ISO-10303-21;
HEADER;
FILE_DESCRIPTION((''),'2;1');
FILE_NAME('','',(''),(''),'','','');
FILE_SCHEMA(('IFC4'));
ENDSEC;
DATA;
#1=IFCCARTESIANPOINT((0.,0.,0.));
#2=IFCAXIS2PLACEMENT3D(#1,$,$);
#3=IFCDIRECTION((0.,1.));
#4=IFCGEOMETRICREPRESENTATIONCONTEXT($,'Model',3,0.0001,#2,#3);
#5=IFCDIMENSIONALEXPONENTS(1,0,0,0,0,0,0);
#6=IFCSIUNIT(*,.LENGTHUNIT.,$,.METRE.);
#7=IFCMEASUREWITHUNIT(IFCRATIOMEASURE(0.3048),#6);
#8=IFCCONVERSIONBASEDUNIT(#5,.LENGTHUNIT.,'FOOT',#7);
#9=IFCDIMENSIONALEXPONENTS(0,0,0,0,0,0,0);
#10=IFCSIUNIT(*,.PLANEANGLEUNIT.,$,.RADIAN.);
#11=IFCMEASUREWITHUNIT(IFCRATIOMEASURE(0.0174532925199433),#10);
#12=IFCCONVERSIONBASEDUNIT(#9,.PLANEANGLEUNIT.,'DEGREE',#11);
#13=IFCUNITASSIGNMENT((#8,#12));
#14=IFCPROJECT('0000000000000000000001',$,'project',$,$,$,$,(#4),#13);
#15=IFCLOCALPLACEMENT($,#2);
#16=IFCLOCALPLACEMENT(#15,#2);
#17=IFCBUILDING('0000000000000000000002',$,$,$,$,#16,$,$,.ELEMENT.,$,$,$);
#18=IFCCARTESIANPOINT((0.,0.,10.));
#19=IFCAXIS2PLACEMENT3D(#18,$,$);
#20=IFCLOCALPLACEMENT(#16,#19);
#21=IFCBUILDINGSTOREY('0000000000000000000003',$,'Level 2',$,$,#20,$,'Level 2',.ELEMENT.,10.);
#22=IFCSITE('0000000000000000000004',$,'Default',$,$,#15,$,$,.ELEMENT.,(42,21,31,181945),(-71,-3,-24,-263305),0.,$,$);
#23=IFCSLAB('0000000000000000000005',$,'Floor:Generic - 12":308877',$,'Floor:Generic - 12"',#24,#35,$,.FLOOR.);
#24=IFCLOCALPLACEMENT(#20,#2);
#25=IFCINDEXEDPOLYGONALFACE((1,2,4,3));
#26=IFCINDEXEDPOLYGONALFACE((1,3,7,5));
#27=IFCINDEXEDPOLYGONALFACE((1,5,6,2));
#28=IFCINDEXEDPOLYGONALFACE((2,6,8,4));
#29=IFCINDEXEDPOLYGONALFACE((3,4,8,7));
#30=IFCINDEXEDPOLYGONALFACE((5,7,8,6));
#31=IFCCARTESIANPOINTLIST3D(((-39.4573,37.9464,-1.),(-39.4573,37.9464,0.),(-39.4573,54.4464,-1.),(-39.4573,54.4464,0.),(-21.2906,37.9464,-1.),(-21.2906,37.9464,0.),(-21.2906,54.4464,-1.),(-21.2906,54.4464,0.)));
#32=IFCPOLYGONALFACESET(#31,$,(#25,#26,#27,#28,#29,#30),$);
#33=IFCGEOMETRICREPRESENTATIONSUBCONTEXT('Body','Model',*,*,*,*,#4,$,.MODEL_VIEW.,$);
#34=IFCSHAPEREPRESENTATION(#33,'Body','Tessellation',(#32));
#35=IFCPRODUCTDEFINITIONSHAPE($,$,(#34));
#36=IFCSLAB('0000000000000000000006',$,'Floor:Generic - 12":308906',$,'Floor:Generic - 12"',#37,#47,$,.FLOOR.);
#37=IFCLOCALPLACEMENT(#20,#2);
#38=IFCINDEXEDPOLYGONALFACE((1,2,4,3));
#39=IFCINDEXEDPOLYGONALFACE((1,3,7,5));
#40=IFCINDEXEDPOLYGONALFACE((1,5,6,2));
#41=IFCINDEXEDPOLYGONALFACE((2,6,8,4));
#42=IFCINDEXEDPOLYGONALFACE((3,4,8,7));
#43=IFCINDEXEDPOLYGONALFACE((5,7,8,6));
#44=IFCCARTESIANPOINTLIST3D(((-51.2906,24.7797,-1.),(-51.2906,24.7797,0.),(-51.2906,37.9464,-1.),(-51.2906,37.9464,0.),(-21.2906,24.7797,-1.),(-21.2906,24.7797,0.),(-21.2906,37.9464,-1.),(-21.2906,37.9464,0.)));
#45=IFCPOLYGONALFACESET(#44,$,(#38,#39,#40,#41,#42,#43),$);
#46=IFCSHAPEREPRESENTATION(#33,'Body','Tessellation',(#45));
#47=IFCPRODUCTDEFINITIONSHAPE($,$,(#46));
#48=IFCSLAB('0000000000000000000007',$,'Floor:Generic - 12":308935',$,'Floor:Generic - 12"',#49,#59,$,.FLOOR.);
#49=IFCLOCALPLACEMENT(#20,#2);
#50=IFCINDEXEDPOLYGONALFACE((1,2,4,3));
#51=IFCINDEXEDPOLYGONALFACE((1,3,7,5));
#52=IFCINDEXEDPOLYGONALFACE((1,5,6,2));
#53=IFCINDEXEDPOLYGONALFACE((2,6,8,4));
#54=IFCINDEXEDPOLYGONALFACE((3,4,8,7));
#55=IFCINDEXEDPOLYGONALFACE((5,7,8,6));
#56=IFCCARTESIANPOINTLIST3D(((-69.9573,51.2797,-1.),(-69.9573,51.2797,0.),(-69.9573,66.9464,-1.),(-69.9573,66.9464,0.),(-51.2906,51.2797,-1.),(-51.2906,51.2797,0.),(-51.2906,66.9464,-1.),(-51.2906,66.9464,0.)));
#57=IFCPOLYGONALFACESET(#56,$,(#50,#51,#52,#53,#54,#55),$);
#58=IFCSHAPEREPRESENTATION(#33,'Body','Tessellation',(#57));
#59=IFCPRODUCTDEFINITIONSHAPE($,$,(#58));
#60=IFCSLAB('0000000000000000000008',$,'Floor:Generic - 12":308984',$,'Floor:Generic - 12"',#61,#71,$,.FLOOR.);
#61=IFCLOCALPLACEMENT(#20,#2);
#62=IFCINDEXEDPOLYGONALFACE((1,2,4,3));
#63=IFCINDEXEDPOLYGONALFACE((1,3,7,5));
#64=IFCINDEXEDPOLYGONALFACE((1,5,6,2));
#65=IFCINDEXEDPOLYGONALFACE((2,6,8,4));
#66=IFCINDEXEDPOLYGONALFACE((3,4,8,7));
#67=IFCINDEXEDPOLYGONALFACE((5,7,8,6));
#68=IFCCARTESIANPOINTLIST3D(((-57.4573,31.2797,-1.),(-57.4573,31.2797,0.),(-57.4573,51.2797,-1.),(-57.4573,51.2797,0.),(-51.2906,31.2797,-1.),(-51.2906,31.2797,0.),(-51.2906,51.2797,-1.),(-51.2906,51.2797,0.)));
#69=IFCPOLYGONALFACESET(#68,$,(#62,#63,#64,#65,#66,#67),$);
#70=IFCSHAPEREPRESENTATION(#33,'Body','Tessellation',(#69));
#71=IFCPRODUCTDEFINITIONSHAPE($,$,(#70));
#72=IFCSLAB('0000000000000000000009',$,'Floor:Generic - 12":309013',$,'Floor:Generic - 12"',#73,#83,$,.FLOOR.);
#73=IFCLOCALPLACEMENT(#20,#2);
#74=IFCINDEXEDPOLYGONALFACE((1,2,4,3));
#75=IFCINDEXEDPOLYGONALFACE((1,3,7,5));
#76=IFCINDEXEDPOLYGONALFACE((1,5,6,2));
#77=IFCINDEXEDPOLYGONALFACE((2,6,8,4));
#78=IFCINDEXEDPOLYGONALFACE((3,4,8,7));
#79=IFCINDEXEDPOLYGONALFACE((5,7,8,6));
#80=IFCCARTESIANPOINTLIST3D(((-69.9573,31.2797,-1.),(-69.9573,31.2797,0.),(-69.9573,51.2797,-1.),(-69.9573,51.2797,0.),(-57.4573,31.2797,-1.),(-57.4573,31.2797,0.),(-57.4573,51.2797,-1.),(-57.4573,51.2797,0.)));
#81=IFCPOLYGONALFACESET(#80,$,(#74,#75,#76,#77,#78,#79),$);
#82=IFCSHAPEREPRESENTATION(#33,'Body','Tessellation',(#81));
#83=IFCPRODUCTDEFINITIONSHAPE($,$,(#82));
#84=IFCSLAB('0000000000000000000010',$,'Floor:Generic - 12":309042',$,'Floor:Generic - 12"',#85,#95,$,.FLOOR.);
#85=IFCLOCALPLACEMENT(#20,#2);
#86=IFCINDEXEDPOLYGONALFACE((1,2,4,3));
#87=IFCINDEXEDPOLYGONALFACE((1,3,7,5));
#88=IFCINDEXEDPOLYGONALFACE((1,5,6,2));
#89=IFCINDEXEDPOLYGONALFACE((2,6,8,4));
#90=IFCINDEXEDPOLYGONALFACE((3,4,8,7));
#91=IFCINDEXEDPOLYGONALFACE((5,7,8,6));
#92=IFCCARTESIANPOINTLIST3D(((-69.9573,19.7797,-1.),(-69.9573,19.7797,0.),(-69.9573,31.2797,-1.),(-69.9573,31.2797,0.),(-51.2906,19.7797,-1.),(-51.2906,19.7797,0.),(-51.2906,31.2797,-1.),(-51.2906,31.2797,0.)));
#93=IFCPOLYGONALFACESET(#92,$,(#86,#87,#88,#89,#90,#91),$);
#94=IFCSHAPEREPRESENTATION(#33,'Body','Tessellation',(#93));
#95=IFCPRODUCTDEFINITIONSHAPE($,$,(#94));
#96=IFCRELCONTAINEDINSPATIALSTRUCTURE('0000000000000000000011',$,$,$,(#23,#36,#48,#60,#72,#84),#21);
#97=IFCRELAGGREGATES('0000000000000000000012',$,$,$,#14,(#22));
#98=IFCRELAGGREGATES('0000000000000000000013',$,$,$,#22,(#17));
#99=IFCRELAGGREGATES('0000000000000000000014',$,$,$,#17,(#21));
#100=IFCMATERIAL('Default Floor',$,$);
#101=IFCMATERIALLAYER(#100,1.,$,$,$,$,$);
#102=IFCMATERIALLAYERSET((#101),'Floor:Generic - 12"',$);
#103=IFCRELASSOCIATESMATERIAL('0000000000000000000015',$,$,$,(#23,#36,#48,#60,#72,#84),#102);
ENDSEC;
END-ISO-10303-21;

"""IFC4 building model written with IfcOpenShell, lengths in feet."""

from ifc_helpers import new_model, entity, si_unit, converted_unit, direction, frame, frame_2d, origin, place, context, subcontext, project, spatial, rectangle, extrude, material, layer, layer_set, layer_usage, element, save


model = new_model("IFC4")

# Units and contexts
model_context = context("Model", 3, precision=0.0001, world=origin(), true_north=direction((0.0, 1.0)))
body_context = subcontext(model_context, "Body", "Model", "MODEL_VIEW")
ifc_project = project(units=[converted_unit("LENGTHUNIT", "FOOT", entity("IfcRatioMeasure", 0.3048), si_unit("LENGTHUNIT", "METRE"), dimensions=[1, 0, 0, 0, 0, 0, 0]), converted_unit("PLANEANGLEUNIT", "DEGREE", entity("IfcRatioMeasure", 0.0174532925199433), si_unit("PLANEANGLEUNIT", "RADIAN"), dimensions=[0, 0, 0, 0, 0, 0, 0])], contexts=[model_context])

# Site, building, storey
site_placement = place(None, origin())
site = spatial("IfcSite", under=ifc_project, at=site_placement, Name="Default", CompositionType="ELEMENT", RefLatitude=(42, 21, 31, 181945), RefLongitude=(-71, -3, -24, -263305), RefElevation=0.0)
building_placement = place(site_placement, origin())
building = spatial("IfcBuilding", under=site, at=building_placement, CompositionType="ELEMENT")
storey_placement = place(building_placement, frame((0.0, 0.0, 10.0)))
storey = spatial("IfcBuildingStorey", under=building, at=storey_placement, Name="Level 2", LongName="Level 2", CompositionType="ELEMENT", Elevation=10.0)

# Slabs
ifc_material_1 = material(Name="Default Floor")
ifc_layer_1 = layer(ifc_material_1, 1.0)
ifc_layer_set_1 = layer_set([ifc_layer_1], Name="Floor:Generic - 12\"")
ifc_layer_usage_1 = layer_usage(ifc_layer_set_1, "AXIS3", "POSITIVE", 0.0)
slab_1_placement = place(storey_placement, origin())
element("IfcSlab", 1, at=slab_1_placement, inside=storey, material=ifc_layer_usage_1, Name="Floor:Generic - 12\":308877", ObjectType="Floor:Generic - 12\"", PredefinedType="FLOOR", context=body_context, shape_type="SweptSolid", body=[
    extrude(rectangle(XDim=16.5, YDim=18.1667, at=frame_2d((0.0, 0.0), x_axis=(1.0, 0.0))), frame((-30.3739, 46.1964, 0.0), z_axis=(0.0, 0.0, -1.0), x_axis=(0.0, 1.0, 0.0)), (0.0, 0.0, 1.0), 1.0),
])
ifc_layer_usage_2 = layer_usage(ifc_layer_set_1, "AXIS3", "POSITIVE", 0.0)
slab_2_placement = place(storey_placement, origin())
element("IfcSlab", 2, at=slab_2_placement, inside=storey, material=ifc_layer_usage_2, Name="Floor:Generic - 12\":308906", ObjectType="Floor:Generic - 12\"", PredefinedType="FLOOR", context=body_context, shape_type="SweptSolid", body=[
    extrude(rectangle(XDim=13.1667, YDim=30.0, at=frame_2d((0.0, 0.0), x_axis=(1.0, 0.0))), frame((-36.2906, 31.3631, 0.0), z_axis=(0.0, 0.0, -1.0), x_axis=(0.0, 1.0, 0.0)), (0.0, 0.0, 1.0), 1.0),
])
ifc_layer_usage_3 = layer_usage(ifc_layer_set_1, "AXIS3", "POSITIVE", 0.0)
slab_3_placement = place(storey_placement, origin())
element("IfcSlab", 3, at=slab_3_placement, inside=storey, material=ifc_layer_usage_3, Name="Floor:Generic - 12\":308935", ObjectType="Floor:Generic - 12\"", PredefinedType="FLOOR", context=body_context, shape_type="SweptSolid", body=[
    extrude(rectangle(XDim=15.6667, YDim=18.6667, at=frame_2d((0.0, 0.0), x_axis=(1.0, 0.0))), frame((-60.6239, 59.1131, 0.0), z_axis=(0.0, 0.0, -1.0), x_axis=(0.0, 1.0, 0.0)), (0.0, 0.0, 1.0), 1.0),
])
ifc_layer_usage_4 = layer_usage(ifc_layer_set_1, "AXIS3", "POSITIVE", 0.0)
slab_4_placement = place(storey_placement, origin())
element("IfcSlab", 4, at=slab_4_placement, inside=storey, material=ifc_layer_usage_4, Name="Floor:Generic - 12\":308984", ObjectType="Floor:Generic - 12\"", PredefinedType="FLOOR", context=body_context, shape_type="SweptSolid", body=[
    extrude(rectangle(XDim=20.0, YDim=6.1667, at=frame_2d((0.0, 0.0), x_axis=(1.0, 0.0))), frame((-54.3739, 41.2797, 0.0), z_axis=(0.0, 0.0, -1.0), x_axis=(0.0, 1.0, 0.0)), (0.0, 0.0, 1.0), 1.0),
])
ifc_layer_usage_5 = layer_usage(ifc_layer_set_1, "AXIS3", "POSITIVE", 0.0)
slab_5_placement = place(storey_placement, origin())
element("IfcSlab", 5, at=slab_5_placement, inside=storey, material=ifc_layer_usage_5, Name="Floor:Generic - 12\":309013", ObjectType="Floor:Generic - 12\"", PredefinedType="FLOOR", context=body_context, shape_type="SweptSolid", body=[
    extrude(rectangle(XDim=20.0, YDim=12.5, at=frame_2d((0.0, 0.0), x_axis=(1.0, 0.0))), frame((-63.7073, 41.2797, 0.0), z_axis=(0.0, 0.0, -1.0), x_axis=(0.0, 1.0, 0.0)), (0.0, 0.0, 1.0), 1.0),
])
ifc_layer_usage_6 = layer_usage(ifc_layer_set_1, "AXIS3", "POSITIVE", 0.0)
slab_6_placement = place(storey_placement, origin())
element("IfcSlab", 6, at=slab_6_placement, inside=storey, material=ifc_layer_usage_6, Name="Floor:Generic - 12\":309042", ObjectType="Floor:Generic - 12\"", PredefinedType="FLOOR", context=body_context, shape_type="SweptSolid", body=[
    extrude(rectangle(XDim=11.5, YDim=18.6667, at=frame_2d((0.0, 0.0), x_axis=(1.0, 0.0))), frame((-60.6239, 25.5297, 0.0), z_axis=(0.0, 0.0, -1.0), x_axis=(0.0, 1.0, 0.0)), (0.0, 0.0, 1.0), 1.0),
])

save(model, "model.ifc")
